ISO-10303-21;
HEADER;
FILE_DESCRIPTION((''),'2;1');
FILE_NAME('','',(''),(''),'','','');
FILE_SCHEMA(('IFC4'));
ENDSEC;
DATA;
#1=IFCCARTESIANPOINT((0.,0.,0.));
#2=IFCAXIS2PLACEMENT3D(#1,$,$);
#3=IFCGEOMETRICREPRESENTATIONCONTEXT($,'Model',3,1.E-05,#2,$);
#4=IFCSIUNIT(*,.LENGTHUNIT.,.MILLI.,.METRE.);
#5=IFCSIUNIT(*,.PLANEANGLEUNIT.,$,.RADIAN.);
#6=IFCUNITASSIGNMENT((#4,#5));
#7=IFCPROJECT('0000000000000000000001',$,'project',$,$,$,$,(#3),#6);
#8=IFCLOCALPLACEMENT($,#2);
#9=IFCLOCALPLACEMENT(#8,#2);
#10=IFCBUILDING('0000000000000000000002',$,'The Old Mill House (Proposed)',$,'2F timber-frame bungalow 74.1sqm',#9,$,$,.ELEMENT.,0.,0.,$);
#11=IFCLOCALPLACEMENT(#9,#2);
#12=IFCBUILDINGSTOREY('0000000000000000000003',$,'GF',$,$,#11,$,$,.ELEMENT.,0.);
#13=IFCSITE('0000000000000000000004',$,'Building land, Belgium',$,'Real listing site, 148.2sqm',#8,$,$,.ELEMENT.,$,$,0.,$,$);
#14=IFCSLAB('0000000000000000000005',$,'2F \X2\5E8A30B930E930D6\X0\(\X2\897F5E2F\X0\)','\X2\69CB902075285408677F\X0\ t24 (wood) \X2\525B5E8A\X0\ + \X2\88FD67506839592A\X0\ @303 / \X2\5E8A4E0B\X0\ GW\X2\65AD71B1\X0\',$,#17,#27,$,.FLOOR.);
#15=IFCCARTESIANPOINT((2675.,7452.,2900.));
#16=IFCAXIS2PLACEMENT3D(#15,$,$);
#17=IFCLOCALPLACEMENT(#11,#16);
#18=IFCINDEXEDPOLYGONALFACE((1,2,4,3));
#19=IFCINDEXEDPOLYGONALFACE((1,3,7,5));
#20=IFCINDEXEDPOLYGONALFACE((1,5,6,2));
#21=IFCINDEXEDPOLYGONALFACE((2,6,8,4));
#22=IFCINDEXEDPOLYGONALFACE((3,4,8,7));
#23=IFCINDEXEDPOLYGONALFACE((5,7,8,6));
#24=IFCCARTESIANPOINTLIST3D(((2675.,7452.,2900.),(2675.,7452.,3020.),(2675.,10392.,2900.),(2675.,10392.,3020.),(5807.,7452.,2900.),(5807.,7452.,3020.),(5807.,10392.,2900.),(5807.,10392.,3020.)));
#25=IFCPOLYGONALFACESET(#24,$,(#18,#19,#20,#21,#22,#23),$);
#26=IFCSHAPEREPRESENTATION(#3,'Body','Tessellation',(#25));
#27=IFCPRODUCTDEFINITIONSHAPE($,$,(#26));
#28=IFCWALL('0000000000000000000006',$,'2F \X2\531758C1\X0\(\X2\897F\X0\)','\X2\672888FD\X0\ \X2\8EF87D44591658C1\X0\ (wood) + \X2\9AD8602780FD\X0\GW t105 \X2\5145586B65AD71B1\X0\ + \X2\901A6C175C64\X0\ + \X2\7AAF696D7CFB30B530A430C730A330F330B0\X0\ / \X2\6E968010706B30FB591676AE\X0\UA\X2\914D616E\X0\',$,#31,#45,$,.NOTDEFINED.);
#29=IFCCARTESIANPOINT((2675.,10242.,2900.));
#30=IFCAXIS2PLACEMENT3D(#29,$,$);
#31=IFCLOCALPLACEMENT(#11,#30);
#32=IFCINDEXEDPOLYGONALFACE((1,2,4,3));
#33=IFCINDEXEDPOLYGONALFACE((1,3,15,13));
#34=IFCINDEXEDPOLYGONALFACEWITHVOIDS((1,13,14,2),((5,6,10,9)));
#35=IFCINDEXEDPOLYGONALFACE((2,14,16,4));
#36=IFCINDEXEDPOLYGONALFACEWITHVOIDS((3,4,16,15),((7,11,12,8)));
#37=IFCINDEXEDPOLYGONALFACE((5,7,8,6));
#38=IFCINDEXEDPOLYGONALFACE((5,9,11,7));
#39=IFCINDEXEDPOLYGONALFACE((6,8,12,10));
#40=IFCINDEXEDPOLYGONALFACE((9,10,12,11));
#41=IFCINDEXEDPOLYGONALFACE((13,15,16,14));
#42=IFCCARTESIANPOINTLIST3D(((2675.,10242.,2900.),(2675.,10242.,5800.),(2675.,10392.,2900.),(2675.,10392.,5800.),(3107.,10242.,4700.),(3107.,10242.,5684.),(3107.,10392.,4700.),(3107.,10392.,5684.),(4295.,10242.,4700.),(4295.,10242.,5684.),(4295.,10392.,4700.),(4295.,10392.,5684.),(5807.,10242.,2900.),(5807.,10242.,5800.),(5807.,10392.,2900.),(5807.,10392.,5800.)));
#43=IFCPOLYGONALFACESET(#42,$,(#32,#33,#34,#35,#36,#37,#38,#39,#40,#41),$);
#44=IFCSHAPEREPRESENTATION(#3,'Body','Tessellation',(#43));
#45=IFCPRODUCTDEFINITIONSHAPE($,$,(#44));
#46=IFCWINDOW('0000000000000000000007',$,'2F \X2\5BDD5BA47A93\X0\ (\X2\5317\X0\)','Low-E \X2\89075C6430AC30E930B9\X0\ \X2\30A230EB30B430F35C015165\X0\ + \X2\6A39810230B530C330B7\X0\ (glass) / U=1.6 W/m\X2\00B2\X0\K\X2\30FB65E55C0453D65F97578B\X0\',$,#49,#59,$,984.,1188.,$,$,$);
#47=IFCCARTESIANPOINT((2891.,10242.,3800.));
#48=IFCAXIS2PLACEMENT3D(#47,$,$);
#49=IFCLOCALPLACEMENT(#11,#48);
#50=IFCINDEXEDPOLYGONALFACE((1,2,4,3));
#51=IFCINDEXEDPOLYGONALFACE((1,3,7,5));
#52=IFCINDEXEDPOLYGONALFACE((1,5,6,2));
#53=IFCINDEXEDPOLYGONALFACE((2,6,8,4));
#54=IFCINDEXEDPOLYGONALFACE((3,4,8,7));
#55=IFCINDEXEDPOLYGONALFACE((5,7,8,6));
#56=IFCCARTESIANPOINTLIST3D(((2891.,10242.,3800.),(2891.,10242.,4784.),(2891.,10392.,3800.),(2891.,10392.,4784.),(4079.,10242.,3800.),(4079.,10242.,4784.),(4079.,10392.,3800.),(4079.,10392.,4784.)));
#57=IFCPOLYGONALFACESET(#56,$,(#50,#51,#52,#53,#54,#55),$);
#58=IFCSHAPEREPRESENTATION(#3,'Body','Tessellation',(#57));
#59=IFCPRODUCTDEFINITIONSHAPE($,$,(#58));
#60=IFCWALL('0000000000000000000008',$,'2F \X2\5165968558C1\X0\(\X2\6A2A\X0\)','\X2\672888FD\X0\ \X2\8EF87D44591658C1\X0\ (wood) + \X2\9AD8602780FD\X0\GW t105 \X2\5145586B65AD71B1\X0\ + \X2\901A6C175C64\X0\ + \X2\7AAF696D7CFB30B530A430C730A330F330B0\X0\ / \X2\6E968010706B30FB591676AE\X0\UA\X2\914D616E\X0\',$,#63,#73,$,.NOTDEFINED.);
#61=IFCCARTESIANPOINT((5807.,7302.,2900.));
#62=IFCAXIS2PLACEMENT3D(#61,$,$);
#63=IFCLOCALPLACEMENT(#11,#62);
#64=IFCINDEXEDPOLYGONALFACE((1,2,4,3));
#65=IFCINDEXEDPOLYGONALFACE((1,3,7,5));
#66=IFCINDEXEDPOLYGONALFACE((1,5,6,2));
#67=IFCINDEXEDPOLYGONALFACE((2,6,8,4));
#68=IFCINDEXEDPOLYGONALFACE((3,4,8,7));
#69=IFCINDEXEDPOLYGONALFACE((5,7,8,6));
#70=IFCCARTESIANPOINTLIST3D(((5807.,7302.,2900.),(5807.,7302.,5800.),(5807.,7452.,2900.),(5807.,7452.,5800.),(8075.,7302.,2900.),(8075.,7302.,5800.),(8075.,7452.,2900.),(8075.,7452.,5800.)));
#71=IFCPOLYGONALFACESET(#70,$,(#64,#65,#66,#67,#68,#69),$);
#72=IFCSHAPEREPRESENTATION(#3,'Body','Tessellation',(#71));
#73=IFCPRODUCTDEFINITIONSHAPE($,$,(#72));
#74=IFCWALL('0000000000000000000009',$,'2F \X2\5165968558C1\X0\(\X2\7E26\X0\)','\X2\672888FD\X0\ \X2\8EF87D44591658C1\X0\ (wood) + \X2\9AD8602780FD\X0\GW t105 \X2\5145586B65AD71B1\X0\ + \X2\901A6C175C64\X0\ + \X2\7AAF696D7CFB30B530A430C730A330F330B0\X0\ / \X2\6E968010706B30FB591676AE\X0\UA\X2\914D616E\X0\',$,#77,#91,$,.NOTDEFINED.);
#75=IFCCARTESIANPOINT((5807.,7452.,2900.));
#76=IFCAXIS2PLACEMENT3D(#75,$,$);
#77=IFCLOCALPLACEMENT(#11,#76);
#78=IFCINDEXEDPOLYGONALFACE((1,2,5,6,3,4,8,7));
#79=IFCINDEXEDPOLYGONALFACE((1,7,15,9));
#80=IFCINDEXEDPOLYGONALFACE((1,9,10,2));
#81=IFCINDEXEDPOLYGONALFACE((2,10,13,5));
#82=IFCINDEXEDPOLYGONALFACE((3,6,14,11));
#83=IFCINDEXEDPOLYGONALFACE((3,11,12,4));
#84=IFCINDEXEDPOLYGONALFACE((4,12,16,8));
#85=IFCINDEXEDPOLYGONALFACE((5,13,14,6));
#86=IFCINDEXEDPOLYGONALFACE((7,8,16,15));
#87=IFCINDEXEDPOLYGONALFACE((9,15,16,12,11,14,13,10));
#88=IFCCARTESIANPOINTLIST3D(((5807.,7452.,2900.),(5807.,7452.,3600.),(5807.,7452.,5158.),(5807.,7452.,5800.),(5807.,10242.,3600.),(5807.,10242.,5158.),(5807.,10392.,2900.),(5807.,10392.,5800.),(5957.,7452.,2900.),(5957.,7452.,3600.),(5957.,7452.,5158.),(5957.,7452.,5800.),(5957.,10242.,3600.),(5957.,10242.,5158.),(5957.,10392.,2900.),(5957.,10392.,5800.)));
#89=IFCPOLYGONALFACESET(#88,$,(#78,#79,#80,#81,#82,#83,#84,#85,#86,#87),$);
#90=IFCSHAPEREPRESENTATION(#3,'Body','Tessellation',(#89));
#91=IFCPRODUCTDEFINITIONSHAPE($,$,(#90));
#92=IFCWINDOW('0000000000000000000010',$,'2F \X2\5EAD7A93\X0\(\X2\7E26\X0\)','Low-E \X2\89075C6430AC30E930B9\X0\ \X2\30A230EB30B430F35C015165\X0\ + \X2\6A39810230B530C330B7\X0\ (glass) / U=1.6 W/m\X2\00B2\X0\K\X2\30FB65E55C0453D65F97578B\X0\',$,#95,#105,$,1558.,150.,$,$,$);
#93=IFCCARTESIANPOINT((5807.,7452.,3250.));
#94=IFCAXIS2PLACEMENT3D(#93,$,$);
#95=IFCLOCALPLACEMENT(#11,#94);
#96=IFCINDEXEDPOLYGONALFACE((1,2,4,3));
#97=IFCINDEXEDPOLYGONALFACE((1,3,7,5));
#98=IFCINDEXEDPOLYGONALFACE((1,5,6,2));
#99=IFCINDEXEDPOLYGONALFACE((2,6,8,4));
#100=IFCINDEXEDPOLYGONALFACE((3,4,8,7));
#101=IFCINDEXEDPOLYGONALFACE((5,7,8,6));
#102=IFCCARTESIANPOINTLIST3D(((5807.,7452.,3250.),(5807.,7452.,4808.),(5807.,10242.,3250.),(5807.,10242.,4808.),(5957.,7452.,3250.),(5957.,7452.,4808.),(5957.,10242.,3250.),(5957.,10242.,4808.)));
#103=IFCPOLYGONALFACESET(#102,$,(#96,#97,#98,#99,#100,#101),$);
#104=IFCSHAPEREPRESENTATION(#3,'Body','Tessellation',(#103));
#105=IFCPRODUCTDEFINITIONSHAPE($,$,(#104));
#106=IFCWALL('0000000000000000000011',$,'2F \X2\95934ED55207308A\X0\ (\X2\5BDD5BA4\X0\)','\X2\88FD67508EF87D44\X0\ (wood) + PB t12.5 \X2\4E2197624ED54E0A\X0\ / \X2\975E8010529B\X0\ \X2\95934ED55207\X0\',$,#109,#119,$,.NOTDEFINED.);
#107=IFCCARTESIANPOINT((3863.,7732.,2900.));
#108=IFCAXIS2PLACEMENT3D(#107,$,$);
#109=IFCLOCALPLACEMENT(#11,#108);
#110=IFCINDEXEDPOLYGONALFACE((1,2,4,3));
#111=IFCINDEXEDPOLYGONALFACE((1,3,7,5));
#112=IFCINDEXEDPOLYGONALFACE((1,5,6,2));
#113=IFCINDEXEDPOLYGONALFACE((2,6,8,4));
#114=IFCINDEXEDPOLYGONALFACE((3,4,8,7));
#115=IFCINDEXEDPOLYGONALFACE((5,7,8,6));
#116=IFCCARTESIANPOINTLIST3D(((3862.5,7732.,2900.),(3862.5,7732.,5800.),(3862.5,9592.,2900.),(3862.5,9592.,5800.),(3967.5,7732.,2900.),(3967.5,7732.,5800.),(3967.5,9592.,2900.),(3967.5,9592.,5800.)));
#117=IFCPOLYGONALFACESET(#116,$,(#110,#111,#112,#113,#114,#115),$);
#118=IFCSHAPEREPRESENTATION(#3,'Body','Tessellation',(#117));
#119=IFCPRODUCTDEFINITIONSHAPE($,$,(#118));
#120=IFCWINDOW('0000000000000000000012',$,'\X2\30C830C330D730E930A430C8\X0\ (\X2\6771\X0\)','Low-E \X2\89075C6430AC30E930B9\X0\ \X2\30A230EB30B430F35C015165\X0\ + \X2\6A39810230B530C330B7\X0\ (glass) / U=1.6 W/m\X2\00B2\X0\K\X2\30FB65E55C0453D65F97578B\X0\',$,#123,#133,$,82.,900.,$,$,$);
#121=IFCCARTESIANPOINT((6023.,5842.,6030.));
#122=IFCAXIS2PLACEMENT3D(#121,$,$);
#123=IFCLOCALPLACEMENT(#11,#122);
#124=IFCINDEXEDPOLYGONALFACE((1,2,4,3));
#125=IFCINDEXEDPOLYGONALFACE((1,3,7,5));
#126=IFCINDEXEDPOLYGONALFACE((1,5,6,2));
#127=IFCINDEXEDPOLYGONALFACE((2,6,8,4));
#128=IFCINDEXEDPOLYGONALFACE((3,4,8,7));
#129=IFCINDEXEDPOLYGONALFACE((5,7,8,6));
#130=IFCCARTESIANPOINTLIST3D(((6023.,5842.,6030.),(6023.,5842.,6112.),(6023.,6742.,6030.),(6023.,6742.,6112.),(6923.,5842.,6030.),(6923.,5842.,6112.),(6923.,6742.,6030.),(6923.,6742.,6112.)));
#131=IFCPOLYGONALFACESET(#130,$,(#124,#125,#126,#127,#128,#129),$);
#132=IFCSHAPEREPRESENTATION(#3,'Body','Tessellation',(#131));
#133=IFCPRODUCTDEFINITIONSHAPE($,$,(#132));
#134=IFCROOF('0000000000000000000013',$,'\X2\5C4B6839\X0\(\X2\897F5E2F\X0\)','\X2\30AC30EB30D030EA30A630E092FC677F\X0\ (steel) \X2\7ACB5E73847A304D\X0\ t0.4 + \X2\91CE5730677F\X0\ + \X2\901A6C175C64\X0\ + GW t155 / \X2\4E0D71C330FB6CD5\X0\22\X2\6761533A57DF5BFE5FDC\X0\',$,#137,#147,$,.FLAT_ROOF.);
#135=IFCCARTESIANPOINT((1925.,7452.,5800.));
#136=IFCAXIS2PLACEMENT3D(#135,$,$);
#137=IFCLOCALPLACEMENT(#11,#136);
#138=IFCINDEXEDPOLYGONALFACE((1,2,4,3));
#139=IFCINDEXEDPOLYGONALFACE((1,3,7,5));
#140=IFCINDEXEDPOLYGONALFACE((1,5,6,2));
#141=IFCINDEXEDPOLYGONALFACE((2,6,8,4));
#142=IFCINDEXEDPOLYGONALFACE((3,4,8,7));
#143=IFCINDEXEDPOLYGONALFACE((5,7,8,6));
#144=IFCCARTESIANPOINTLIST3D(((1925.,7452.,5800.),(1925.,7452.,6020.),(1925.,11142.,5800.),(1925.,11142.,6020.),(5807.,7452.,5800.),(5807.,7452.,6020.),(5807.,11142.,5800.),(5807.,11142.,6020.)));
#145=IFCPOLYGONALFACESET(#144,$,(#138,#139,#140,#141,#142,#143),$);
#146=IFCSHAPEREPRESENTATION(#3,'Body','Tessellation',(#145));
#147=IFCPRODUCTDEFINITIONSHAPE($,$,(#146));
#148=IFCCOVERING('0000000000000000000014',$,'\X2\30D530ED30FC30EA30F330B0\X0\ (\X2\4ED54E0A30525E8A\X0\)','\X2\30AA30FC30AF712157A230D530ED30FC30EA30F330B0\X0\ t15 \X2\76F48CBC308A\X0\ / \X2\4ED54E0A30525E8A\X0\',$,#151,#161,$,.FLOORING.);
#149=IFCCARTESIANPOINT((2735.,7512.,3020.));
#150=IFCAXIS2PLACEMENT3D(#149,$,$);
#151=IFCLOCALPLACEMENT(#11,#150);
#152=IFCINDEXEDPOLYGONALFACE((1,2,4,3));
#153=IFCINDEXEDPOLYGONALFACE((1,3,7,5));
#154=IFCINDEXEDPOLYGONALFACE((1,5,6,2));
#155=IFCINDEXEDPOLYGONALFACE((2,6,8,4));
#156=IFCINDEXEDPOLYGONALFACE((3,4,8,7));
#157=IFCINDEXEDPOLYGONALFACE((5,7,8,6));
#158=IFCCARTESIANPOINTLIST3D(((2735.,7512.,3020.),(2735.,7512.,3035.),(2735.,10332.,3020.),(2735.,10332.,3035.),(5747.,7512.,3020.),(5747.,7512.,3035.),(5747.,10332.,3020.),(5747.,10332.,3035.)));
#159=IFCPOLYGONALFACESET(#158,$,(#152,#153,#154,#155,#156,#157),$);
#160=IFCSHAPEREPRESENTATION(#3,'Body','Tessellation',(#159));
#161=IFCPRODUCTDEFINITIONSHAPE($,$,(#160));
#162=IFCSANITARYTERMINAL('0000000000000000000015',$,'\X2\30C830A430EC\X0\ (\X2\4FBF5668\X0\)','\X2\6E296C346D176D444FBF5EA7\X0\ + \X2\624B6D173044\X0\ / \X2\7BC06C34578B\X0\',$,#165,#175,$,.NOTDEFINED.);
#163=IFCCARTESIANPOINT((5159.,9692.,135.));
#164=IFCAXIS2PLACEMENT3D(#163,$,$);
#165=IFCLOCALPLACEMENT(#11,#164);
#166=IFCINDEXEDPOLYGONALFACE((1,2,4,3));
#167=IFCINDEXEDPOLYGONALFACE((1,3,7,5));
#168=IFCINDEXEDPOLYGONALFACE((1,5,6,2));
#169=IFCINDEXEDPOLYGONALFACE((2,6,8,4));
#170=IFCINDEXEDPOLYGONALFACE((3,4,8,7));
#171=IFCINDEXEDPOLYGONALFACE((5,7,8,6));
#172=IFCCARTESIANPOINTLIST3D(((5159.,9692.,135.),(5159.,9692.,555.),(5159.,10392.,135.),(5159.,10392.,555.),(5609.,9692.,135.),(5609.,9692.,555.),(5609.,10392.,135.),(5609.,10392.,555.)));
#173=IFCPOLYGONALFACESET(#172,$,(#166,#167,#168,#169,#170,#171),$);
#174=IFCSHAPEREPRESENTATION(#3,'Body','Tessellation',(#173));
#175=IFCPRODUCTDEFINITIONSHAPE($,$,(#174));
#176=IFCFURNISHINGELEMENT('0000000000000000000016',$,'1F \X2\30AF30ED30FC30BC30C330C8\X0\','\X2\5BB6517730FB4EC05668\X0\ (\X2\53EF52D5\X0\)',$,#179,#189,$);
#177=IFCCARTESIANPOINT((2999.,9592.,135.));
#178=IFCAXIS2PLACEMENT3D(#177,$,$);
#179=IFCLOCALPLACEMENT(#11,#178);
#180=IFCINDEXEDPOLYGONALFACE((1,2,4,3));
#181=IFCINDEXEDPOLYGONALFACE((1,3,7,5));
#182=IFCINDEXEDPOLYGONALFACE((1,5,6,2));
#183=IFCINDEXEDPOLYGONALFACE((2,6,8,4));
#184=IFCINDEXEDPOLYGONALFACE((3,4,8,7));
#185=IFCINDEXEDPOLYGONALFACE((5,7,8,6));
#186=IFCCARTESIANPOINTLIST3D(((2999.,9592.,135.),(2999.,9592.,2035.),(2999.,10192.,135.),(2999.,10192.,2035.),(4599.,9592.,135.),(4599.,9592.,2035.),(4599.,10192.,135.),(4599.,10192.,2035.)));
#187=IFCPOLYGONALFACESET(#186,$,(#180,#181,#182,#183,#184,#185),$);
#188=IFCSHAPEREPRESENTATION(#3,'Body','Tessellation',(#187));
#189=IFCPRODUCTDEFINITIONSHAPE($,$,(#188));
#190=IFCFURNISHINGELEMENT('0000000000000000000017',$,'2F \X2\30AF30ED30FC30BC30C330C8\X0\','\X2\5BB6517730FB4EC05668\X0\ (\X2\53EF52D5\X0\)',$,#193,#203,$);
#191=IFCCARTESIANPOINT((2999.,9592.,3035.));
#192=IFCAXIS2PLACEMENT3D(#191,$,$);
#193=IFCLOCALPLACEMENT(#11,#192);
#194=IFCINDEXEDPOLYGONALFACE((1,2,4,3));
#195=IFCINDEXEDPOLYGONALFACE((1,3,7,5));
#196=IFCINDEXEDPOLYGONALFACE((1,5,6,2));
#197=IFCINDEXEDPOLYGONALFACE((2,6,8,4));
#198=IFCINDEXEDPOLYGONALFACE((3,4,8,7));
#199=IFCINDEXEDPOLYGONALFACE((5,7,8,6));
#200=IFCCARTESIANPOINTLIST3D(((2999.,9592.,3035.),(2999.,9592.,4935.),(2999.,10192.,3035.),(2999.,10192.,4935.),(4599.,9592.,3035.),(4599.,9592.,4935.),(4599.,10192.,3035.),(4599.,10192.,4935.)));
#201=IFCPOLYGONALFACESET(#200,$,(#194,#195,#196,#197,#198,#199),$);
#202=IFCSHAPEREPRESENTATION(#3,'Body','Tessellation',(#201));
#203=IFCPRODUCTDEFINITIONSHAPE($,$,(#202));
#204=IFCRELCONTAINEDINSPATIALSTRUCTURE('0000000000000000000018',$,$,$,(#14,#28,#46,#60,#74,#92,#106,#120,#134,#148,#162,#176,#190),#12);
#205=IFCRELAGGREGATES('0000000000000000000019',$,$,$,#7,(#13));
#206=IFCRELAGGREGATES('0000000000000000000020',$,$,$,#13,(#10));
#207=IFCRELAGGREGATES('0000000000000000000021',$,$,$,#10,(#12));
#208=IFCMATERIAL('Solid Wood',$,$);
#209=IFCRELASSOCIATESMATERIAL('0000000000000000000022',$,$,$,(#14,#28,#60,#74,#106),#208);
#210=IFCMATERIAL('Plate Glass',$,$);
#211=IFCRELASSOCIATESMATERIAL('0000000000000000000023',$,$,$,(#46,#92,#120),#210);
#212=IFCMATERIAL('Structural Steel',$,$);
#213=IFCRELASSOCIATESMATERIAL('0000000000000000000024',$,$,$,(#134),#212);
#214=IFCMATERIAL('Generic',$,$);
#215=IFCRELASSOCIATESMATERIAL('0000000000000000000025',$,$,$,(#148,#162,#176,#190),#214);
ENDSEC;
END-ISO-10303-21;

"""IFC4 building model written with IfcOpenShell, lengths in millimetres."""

from ifc_helpers import new_model, si_unit, frame, frame_2d, origin, place, context, project, spatial, rectangle, extrude, material, element, fill, save


model = new_model("IFC4")

# Units and contexts
model_context = context("Model", 3, precision=1e-05, world=origin())
ifc_project = project(units=[si_unit("LENGTHUNIT", "METRE", prefix="MILLI"), si_unit("PLANEANGLEUNIT", "RADIAN")], contexts=[model_context])

# Site, building, storey
site_placement = place(None, origin())
site = spatial("IfcSite", under=ifc_project, at=site_placement, Name="Building land, Belgium", ObjectType="Real listing site, 148.2sqm", CompositionType="ELEMENT", RefElevation=0.0)
building_placement = place(site_placement, origin())
building = spatial("IfcBuilding", under=site, at=building_placement, Name="The Old Mill House (Proposed)", ObjectType="2F timber-frame bungalow 74.1sqm", CompositionType="ELEMENT", ElevationOfRefHeight=0.0, ElevationOfTerrain=0.0)
storey_placement = place(building_placement, origin())
storey = spatial("IfcBuildingStorey", under=building, at=storey_placement, Name="GF", CompositionType="ELEMENT", Elevation=0.0)

# Slab
ifc_material_1 = material(Name="Solid Wood")
slab_placement = place(storey_placement, frame((2675.0, 7452.0, 2900.0)))
element("IfcSlab", 1, at=slab_placement, inside=storey, material=ifc_material_1, Name="2F 床スラブ(西帯)", Description="構造用合板 t24 (wood) 剛床 + 製材根太 @303 / 床下 GW断熱", PredefinedType="FLOOR", context=model_context, shape_type="SweptSolid", body=[
    extrude(rectangle(XDim=3132.0, YDim=2940.0, at=frame_2d((1566.0, 1470.0))), frame((2675.0, 7452.0, 2900.0)), (0.0, 0.0, 1.0), 120.0),
])

# Wall, opening, window
wall_1_placement = place(storey_placement, frame((2675.0, 10242.0, 2900.0)))
wall_1 = element("IfcWall", 2, at=wall_1_placement, inside=storey, material=ifc_material_1, Name="2F 北壁(西)", Description="木製 軸組外壁 (wood) + 高性能GW t105 充填断熱 + 通気層 + 窯業系サイディング / 準耐火・外皮UA配慮", PredefinedType="NOTDEFINED", context=model_context, shape_type="SweptSolid", body=[
    extrude(rectangle(XDim=3132.0, YDim=150.0, at=frame_2d((1566.0, 75.0))), frame((2675.0, 10242.0, 2900.0)), (0.0, 0.0, 1.0), 2900.0),
])
opening_1_placement = place(storey_placement, frame((2891.0, 10242.0, 3800.0)))
opening_1 = element("IfcOpeningElement", 3, at=opening_1_placement, cuts=wall_1, PredefinedType="NOTDEFINED", context=model_context, shape_type="SweptSolid", body=[
    extrude(rectangle(XDim=1188.0, YDim=150.0, at=frame_2d((594.0, 75.0))), frame((2891.0, 10242.0, 3800.0)), (0.0, 0.0, 1.0), 984.0),
])
ifc_material_2 = material(Name="Plate Glass")
window_1_placement = place(storey_placement, frame((2891.0, 10242.0, 3800.0)))
window_1 = element("IfcWindow", 4, at=window_1_placement, inside=storey, material=ifc_material_2, Name="2F 寝室窓 (北)", Description="Low-E 複層ガラス アルゴン封入 + 樹脂サッシ (glass) / U=1.6 W/m²K・日射取得型", OverallHeight=984.0, OverallWidth=1188.0, context=model_context, shape_type="SweptSolid", body=[
    extrude(rectangle(XDim=1188.0, YDim=150.0, at=frame_2d((594.0, 75.0))), frame((2891.0, 10242.0, 3800.0)), (0.0, 0.0, 1.0), 984.0),
])
fill(opening_1, window_1)

# Wall
wall_2_placement = place(storey_placement, frame((5807.0, 7302.0, 2900.0)))
element("IfcWall", 5, at=wall_2_placement, inside=storey, material=ifc_material_1, Name="2F 入隅壁(横)", Description="木製 軸組外壁 (wood) + 高性能GW t105 充填断熱 + 通気層 + 窯業系サイディング / 準耐火・外皮UA配慮", PredefinedType="NOTDEFINED", context=model_context, shape_type="SweptSolid", body=[
    extrude(rectangle(XDim=2268.0, YDim=150.0, at=frame_2d((1134.0, 75.0))), frame((5807.0, 7302.0, 2900.0)), (0.0, 0.0, 1.0), 2900.0),
])

# Wall, opening, window
wall_3_placement = place(storey_placement, frame((5807.0, 7452.0, 2900.0)))
wall_3 = element("IfcWall", 6, at=wall_3_placement, inside=storey, material=ifc_material_1, Name="2F 入隅壁(縦)", Description="木製 軸組外壁 (wood) + 高性能GW t105 充填断熱 + 通気層 + 窯業系サイディング / 準耐火・外皮UA配慮", PredefinedType="NOTDEFINED", context=model_context, shape_type="SweptSolid", body=[
    extrude(rectangle(XDim=150.0, YDim=2940.0, at=frame_2d((75.0, 1470.0))), frame((5807.0, 7452.0, 2900.0)), (0.0, 0.0, 1.0), 2900.0),
])
opening_2_placement = place(storey_placement, frame((5807.0, 7452.0, 3250.0)))
opening_2 = element("IfcOpeningElement", 7, at=opening_2_placement, cuts=wall_3, PredefinedType="NOTDEFINED", context=model_context, shape_type="SweptSolid", body=[
    extrude(rectangle(XDim=150.0, YDim=2790.0, at=frame_2d((75.0, 1395.0))), frame((5807.0, 7452.0, 3250.0)), (0.0, 0.0, 1.0), 1558.0),
])
window_2_placement = place(storey_placement, frame((5807.0, 7452.0, 3250.0)))
window_2 = element("IfcWindow", 8, at=window_2_placement, inside=storey, material=ifc_material_2, Name="2F 庭窓(縦)", Description="Low-E 複層ガラス アルゴン封入 + 樹脂サッシ (glass) / U=1.6 W/m²K・日射取得型", OverallHeight=1558.0, OverallWidth=150.0, context=model_context, shape_type="SweptSolid", body=[
    extrude(rectangle(XDim=150.0, YDim=2790.0, at=frame_2d((75.0, 1395.0))), frame((5807.0, 7452.0, 3250.0)), (0.0, 0.0, 1.0), 1558.0),
])
fill(opening_2, window_2)

# Wall
wall_4_placement = place(storey_placement, frame((3863.0, 7732.0, 2900.0)))
element("IfcWall", 9, at=wall_4_placement, inside=storey, material=ifc_material_1, Name="2F 間仕切り (寝室)", Description="製材軸組 (wood) + PB t12.5 両面仕上 / 非耐力 間仕切", PredefinedType="NOTDEFINED", context=model_context, shape_type="SweptSolid", body=[
    extrude(rectangle(XDim=105.0, YDim=1860.0, at=frame_2d((52.0, 930.0))), frame((3863.0, 7732.0, 2900.0)), (0.0, 0.0, 1.0), 2900.0),
])

# Window
window_3_placement = place(storey_placement, frame((6023.0, 5842.0, 6030.0)))
element("IfcWindow", 10, at=window_3_placement, inside=storey, material=ifc_material_2, Name="トップライト (東)", Description="Low-E 複層ガラス アルゴン封入 + 樹脂サッシ (glass) / U=1.6 W/m²K・日射取得型", OverallHeight=82.0, OverallWidth=900.0, context=model_context, shape_type="SweptSolid", body=[
    extrude(rectangle(XDim=900.0, YDim=900.0, at=frame_2d((450.0, 450.0))), frame((6023.0, 5842.0, 6030.0)), (0.0, 0.0, 1.0), 82.0),
])

# Roof
ifc_material_3 = material(Name="Structural Steel")
for number, where, name in (
    (11, (1925.0, 7452.0, 5800.0), "屋根(西帯)"),
):
    element("IfcRoof", number, at=place(storey_placement, frame(where)), inside=storey, material=ifc_material_3, Name=name, Description="ガルバリウム鋼板 (steel) 立平葺き t0.4 + 野地板 + 通気層 + GW t155 / 不燃・法22条区域対応", PredefinedType="FLAT_ROOF", context=model_context, shape_type="SweptSolid", body=[
        extrude(rectangle(XDim=3882.0, YDim=3690.0, at=frame_2d((1941.0, 1845.0))), frame((1925.0, 7452.0, 5800.0)), (0.0, 0.0, 1.0), 220.0),
    ])

# Covering
ifc_material_4 = material(Name="Generic")
covering_placement = place(storey_placement, frame((2735.0, 7512.0, 3020.0)))
element("IfcCovering", 12, at=covering_placement, inside=storey, material=ifc_material_4, Name="フローリング (仕上げ床)", Description="オーク無垢フローリング t15 直貼り / 仕上げ床", PredefinedType="FLOORING", context=model_context, shape_type="SweptSolid", body=[
    extrude(rectangle(XDim=3012.0, YDim=2820.0, at=frame_2d((1506.0, 1410.0))), frame((2735.0, 7512.0, 3020.0)), (0.0, 0.0, 1.0), 15.0),
])

# Sanitary terminal
sanitary_terminal_placement = place(storey_placement, frame((5159.0, 9692.0, 135.0)))
element("IfcSanitaryTerminal", 13, at=sanitary_terminal_placement, inside=storey, material=ifc_material_4, Name="トイレ (便器)", Description="温水洗浄便座 + 手洗い / 節水型", PredefinedType="NOTDEFINED", context=model_context, shape_type="SweptSolid", body=[
    extrude(rectangle(XDim=450.0, YDim=700.0, at=frame_2d((225.0, 350.0))), frame((5159.0, 9692.0, 135.0)), (0.0, 0.0, 1.0), 420.0),
])

# Furnishing elements
furnishing_1_placement = place(storey_placement, frame((2999.0, 9592.0, 135.0)))
element("IfcFurnishingElement", 14, at=furnishing_1_placement, inside=storey, material=ifc_material_4, Name="1F クローゼット", Description="家具・什器 (可動)", context=model_context, shape_type="SweptSolid", body=[
    extrude(rectangle(XDim=1600.0, YDim=600.0, at=frame_2d((800.0, 300.0))), frame((2999.0, 9592.0, 135.0)), (0.0, 0.0, 1.0), 1900.0),
])
furnishing_2_placement = place(storey_placement, frame((2999.0, 9592.0, 3035.0)))
element("IfcFurnishingElement", 15, at=furnishing_2_placement, inside=storey, material=ifc_material_4, Name="2F クローゼット", Description="家具・什器 (可動)", context=model_context, shape_type="SweptSolid", body=[
    extrude(rectangle(XDim=1600.0, YDim=600.0, at=frame_2d((800.0, 300.0))), frame((2999.0, 9592.0, 3035.0)), (0.0, 0.0, 1.0), 1900.0),
])

save(model, "model.ifc")
